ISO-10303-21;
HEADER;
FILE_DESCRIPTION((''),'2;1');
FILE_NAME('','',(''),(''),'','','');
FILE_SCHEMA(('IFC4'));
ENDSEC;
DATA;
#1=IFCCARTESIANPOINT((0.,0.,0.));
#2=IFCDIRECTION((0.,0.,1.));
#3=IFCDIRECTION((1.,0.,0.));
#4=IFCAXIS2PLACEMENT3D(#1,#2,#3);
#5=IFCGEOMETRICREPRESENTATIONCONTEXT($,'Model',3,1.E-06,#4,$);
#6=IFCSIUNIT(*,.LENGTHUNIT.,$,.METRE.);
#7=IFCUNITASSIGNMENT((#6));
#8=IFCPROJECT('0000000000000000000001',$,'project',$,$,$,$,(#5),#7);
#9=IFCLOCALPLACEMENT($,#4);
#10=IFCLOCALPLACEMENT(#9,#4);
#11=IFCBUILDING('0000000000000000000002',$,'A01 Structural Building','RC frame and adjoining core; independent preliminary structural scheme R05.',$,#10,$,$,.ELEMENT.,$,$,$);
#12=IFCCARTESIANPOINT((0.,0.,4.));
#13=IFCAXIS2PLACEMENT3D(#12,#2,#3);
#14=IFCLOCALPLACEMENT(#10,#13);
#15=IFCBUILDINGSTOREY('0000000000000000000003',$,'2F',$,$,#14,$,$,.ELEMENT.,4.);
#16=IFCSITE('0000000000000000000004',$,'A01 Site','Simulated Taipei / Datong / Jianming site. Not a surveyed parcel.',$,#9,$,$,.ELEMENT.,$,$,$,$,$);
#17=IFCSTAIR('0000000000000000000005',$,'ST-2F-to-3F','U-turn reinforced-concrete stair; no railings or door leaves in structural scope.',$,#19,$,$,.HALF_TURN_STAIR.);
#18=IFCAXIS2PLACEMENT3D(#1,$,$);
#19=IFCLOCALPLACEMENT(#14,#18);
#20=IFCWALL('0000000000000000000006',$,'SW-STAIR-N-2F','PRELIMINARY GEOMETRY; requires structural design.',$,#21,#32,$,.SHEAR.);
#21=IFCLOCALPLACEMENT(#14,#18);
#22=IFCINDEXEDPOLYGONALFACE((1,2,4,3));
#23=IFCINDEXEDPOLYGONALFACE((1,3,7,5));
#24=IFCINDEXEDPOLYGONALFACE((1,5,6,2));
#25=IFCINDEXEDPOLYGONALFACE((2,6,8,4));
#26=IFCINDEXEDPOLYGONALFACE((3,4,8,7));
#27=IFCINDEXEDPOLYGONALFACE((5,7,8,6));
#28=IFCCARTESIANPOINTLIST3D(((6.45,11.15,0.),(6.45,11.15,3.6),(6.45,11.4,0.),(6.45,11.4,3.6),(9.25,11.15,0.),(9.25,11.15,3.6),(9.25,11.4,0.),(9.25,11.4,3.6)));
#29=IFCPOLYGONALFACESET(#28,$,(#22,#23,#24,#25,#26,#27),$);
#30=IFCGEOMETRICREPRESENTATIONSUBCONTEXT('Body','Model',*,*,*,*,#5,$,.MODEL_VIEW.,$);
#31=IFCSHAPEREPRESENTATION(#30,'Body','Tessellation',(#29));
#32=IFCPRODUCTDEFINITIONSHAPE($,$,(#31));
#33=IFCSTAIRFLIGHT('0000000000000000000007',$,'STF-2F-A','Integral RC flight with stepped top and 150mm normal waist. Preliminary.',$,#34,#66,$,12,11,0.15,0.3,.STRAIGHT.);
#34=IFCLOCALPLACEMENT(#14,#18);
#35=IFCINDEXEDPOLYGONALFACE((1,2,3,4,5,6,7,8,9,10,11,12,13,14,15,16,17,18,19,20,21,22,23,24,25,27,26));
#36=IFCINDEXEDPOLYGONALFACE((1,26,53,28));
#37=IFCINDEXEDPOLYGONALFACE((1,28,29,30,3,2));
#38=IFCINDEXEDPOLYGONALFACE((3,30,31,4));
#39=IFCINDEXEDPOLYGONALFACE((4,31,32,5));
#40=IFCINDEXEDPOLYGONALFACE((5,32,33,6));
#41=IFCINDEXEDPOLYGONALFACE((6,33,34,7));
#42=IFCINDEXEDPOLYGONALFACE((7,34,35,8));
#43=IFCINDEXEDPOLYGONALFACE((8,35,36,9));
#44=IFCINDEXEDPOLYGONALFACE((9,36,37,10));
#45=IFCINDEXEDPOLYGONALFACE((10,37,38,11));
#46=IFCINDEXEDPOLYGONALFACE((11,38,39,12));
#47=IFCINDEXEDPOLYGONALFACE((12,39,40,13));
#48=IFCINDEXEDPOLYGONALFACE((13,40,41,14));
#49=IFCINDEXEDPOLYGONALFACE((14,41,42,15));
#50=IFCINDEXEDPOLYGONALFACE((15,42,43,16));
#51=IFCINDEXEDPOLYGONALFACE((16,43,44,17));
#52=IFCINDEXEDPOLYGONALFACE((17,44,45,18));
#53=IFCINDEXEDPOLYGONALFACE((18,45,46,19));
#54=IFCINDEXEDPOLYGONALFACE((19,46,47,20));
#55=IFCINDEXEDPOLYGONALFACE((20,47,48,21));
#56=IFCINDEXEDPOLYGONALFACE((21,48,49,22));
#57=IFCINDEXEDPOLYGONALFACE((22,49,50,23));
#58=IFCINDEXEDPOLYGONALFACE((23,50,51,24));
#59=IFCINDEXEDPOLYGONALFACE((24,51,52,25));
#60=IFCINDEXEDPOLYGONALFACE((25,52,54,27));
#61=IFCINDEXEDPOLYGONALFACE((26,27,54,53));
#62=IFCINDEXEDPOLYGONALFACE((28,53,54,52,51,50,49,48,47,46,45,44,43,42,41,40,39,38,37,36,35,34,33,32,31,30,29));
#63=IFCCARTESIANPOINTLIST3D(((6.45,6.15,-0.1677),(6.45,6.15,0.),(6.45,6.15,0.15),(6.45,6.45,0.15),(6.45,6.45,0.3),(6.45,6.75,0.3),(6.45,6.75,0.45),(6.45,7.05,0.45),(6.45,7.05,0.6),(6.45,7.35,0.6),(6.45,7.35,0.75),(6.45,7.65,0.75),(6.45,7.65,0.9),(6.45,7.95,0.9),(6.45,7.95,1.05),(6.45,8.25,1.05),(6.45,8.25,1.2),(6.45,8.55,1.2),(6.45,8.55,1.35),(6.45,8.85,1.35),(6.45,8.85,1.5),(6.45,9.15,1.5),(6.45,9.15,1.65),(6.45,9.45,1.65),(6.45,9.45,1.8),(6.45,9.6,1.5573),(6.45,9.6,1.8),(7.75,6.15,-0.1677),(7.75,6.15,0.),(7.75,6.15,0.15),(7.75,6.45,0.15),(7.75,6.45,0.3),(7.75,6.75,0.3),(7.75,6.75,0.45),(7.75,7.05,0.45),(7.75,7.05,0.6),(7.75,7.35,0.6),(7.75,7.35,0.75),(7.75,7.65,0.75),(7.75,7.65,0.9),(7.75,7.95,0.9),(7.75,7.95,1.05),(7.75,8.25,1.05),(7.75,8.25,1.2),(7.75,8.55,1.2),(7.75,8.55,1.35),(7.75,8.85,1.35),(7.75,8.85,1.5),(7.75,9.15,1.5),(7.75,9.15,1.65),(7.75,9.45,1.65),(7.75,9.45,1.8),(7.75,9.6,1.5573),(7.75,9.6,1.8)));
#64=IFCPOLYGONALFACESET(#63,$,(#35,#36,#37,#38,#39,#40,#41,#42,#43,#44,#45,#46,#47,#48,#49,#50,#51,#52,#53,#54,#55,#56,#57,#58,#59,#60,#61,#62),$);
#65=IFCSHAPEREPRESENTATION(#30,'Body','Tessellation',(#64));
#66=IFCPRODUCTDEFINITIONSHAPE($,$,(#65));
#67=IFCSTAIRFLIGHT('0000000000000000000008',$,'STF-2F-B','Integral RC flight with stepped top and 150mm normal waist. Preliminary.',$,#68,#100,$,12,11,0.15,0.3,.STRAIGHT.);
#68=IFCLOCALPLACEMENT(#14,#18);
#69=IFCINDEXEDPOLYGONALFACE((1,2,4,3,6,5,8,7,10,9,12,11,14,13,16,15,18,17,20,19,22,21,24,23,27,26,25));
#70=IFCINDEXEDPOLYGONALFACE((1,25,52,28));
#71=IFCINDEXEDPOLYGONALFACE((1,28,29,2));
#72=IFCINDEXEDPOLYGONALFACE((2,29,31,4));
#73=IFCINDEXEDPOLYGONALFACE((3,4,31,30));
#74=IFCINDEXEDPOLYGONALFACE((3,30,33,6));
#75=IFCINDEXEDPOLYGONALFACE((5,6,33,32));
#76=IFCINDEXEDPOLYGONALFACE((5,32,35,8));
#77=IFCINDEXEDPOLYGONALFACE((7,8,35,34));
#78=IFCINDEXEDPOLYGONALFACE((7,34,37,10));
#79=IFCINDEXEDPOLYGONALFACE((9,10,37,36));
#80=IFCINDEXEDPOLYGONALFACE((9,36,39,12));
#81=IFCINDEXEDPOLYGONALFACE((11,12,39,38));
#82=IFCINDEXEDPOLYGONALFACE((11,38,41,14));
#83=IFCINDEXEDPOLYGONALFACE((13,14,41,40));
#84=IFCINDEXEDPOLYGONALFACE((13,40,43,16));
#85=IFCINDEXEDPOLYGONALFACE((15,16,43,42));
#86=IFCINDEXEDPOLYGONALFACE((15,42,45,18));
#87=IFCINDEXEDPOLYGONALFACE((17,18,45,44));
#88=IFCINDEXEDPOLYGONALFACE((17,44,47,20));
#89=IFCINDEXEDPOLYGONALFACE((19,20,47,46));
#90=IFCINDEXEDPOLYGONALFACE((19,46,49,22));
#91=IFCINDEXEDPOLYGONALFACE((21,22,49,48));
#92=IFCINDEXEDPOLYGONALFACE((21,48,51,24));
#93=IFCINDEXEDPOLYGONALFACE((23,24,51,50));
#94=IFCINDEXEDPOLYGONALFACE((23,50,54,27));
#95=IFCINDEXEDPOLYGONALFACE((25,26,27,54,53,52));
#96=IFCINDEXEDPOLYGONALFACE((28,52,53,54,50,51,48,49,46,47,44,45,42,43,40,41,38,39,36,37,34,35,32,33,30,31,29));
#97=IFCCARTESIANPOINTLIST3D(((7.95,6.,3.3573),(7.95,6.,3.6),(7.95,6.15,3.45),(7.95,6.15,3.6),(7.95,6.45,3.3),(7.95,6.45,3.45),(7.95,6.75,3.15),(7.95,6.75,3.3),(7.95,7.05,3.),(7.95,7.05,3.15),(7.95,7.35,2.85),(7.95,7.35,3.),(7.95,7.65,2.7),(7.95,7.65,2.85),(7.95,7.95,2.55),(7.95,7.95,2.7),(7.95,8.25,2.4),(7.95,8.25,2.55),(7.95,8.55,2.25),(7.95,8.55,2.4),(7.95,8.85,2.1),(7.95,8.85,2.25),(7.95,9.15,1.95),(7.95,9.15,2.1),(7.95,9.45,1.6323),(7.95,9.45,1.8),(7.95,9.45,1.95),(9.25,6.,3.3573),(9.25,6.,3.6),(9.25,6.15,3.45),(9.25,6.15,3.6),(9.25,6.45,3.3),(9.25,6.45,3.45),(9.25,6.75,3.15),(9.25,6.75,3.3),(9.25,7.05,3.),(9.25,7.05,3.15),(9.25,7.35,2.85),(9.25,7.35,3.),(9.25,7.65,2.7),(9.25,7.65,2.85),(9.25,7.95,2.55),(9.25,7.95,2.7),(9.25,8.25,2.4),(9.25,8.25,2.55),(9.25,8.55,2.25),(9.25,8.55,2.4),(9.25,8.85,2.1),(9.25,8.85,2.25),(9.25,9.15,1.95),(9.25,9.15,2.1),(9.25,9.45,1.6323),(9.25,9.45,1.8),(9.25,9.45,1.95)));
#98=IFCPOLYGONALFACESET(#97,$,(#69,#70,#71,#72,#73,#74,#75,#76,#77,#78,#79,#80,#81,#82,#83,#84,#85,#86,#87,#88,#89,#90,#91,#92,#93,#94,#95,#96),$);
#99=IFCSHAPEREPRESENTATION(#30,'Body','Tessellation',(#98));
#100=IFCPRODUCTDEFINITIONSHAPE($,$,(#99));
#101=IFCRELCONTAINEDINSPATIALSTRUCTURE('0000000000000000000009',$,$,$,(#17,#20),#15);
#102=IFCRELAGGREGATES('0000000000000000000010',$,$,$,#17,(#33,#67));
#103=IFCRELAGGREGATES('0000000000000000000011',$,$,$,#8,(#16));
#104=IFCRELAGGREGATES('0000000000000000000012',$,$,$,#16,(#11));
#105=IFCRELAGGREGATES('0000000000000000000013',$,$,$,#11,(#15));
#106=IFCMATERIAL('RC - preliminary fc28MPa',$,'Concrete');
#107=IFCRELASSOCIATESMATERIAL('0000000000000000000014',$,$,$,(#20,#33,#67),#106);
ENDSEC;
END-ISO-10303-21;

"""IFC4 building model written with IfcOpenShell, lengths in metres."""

from ifc_helpers import new_model, si_unit, frame, origin_with_axes, place, context, subcontext, project, spatial, polyline, rectangle, outline, extrude, material, element, aggregate, save


model = new_model("IFC4")

# Units and contexts
model_context = context("Model", 3, precision=1e-06, world=origin_with_axes())
body_context = subcontext(model_context, "Body", "Model", "MODEL_VIEW")
ifc_project = project(units=[si_unit("LENGTHUNIT", "METRE")], contexts=[model_context])

# Site, building, storey
site_placement = place(None, origin_with_axes())
site = spatial("IfcSite", under=ifc_project, at=site_placement, Name="A01 Site", Description="Simulated Taipei / Datong / Jianming site. Not a surveyed parcel.", CompositionType="ELEMENT")
building_placement = place(site_placement, origin_with_axes())
building = spatial("IfcBuilding", under=site, at=building_placement, Name="A01 Structural Building", Description="RC frame and adjoining core; independent preliminary structural scheme R05.", CompositionType="ELEMENT")
storey_placement = place(building_placement, frame((0.0, 0.0, 4.0), z_axis=(0.0, 0.0, 1.0), x_axis=(1.0, 0.0, 0.0)))
storey = spatial("IfcBuildingStorey", under=building, at=storey_placement, Name="2F", CompositionType="ELEMENT", Elevation=4.0)

# Shared definitions
ifc_material = material(Name="RC - preliminary fc28MPa", Category="Concrete")

# Stair
stair_placement = place(storey_placement, origin_with_axes())
stair = element("IfcStair", 1, at=stair_placement, inside=storey, Name="ST-2F-to-3F", Description="U-turn reinforced-concrete stair; no railings or door leaves in structural scope.", PredefinedType="HALF_TURN_STAIR")

# Wall
wall_1_placement = place(storey_placement, frame((7.85, 11.275, 0.0), z_axis=(0.0, 0.0, 1.0), x_axis=(1.0, 0.0, 0.0)))
element("IfcWall", 2, at=wall_1_placement, inside=storey, material=ifc_material, Name="SW-STAIR-N-2F", Description="PRELIMINARY GEOMETRY; requires structural design.", PredefinedType="SHEAR", context=body_context, shape_type="SweptSolid", body=[
    extrude(rectangle(XDim=2.8, YDim=0.25), origin_with_axes(), (0.0, 0.0, 1.0), 3.6),
])

# Stair flights
stair_flight_1_placement = place(storey_placement, origin_with_axes())
stair_flight_1 = element("IfcStairFlight", 3, at=stair_flight_1_placement, material=ifc_material, Name="STF-2F-A", Description="Integral RC flight with stepped top and 150mm normal waist. Preliminary.", NumberOfRisers=12, NumberOfTreads=11, PredefinedType="STRAIGHT", RiserHeight=0.15, TreadLength=0.3, context=body_context, shape_type="SweptSolid", body=[
    extrude(outline(polyline([(0.0, 0.0), (0.0, 0.15), (0.3, 0.15), (0.3, 0.3), (0.6, 0.3), (0.6, 0.45), (0.9, 0.45), (0.9, 0.6), (1.2, 0.6), (1.2, 0.75), (1.5, 0.75), (1.5, 0.9), (1.8, 0.9), (1.8, 1.05), (2.1, 1.05), (2.1, 1.2), (2.4, 1.2), (2.4, 1.35), (2.7, 1.35), (2.7, 1.5), (3.0, 1.5), (3.0, 1.65), (3.3, 1.65), (3.3, 1.8), (3.45, 1.8), (3.45, 1.5573), (0.0, -0.1677), (0.0, 0.0)])), frame((6.45, 6.15, 0.0), z_axis=(1.0, 0.0, 0.0), x_axis=(0.0, 1.0, 0.0)), (0.0, 0.0, 1.0), 1.3),
])
stair_flight_2_placement = place(storey_placement, origin_with_axes())
stair_flight_2 = element("IfcStairFlight", 4, at=stair_flight_2_placement, material=ifc_material, Name="STF-2F-B", Description="Integral RC flight with stepped top and 150mm normal waist. Preliminary.", NumberOfRisers=12, NumberOfTreads=11, PredefinedType="STRAIGHT", RiserHeight=0.15, TreadLength=0.3, context=body_context, shape_type="SweptSolid", body=[
    extrude(outline(polyline([(0.0, 0.0), (0.0, 0.15), (0.3, 0.15), (0.3, 0.3), (0.6, 0.3), (0.6, 0.45), (0.9, 0.45), (0.9, 0.6), (1.2, 0.6), (1.2, 0.75), (1.5, 0.75), (1.5, 0.9), (1.8, 0.9), (1.8, 1.05), (2.1, 1.05), (2.1, 1.2), (2.4, 1.2), (2.4, 1.35), (2.7, 1.35), (2.7, 1.5), (3.0, 1.5), (3.0, 1.65), (3.3, 1.65), (3.3, 1.8), (3.45, 1.8), (3.45, 1.5573), (0.0, -0.1677), (0.0, 0.0)])), frame((9.25, 9.45, 1.8), z_axis=(-1.0, 0.0, 0.0), x_axis=(0.0, -1.0, 0.0)), (0.0, 0.0, 1.0), 1.3),
])
aggregate(stair, [stair_flight_1, stair_flight_2])

save(model, "model.ifc")
